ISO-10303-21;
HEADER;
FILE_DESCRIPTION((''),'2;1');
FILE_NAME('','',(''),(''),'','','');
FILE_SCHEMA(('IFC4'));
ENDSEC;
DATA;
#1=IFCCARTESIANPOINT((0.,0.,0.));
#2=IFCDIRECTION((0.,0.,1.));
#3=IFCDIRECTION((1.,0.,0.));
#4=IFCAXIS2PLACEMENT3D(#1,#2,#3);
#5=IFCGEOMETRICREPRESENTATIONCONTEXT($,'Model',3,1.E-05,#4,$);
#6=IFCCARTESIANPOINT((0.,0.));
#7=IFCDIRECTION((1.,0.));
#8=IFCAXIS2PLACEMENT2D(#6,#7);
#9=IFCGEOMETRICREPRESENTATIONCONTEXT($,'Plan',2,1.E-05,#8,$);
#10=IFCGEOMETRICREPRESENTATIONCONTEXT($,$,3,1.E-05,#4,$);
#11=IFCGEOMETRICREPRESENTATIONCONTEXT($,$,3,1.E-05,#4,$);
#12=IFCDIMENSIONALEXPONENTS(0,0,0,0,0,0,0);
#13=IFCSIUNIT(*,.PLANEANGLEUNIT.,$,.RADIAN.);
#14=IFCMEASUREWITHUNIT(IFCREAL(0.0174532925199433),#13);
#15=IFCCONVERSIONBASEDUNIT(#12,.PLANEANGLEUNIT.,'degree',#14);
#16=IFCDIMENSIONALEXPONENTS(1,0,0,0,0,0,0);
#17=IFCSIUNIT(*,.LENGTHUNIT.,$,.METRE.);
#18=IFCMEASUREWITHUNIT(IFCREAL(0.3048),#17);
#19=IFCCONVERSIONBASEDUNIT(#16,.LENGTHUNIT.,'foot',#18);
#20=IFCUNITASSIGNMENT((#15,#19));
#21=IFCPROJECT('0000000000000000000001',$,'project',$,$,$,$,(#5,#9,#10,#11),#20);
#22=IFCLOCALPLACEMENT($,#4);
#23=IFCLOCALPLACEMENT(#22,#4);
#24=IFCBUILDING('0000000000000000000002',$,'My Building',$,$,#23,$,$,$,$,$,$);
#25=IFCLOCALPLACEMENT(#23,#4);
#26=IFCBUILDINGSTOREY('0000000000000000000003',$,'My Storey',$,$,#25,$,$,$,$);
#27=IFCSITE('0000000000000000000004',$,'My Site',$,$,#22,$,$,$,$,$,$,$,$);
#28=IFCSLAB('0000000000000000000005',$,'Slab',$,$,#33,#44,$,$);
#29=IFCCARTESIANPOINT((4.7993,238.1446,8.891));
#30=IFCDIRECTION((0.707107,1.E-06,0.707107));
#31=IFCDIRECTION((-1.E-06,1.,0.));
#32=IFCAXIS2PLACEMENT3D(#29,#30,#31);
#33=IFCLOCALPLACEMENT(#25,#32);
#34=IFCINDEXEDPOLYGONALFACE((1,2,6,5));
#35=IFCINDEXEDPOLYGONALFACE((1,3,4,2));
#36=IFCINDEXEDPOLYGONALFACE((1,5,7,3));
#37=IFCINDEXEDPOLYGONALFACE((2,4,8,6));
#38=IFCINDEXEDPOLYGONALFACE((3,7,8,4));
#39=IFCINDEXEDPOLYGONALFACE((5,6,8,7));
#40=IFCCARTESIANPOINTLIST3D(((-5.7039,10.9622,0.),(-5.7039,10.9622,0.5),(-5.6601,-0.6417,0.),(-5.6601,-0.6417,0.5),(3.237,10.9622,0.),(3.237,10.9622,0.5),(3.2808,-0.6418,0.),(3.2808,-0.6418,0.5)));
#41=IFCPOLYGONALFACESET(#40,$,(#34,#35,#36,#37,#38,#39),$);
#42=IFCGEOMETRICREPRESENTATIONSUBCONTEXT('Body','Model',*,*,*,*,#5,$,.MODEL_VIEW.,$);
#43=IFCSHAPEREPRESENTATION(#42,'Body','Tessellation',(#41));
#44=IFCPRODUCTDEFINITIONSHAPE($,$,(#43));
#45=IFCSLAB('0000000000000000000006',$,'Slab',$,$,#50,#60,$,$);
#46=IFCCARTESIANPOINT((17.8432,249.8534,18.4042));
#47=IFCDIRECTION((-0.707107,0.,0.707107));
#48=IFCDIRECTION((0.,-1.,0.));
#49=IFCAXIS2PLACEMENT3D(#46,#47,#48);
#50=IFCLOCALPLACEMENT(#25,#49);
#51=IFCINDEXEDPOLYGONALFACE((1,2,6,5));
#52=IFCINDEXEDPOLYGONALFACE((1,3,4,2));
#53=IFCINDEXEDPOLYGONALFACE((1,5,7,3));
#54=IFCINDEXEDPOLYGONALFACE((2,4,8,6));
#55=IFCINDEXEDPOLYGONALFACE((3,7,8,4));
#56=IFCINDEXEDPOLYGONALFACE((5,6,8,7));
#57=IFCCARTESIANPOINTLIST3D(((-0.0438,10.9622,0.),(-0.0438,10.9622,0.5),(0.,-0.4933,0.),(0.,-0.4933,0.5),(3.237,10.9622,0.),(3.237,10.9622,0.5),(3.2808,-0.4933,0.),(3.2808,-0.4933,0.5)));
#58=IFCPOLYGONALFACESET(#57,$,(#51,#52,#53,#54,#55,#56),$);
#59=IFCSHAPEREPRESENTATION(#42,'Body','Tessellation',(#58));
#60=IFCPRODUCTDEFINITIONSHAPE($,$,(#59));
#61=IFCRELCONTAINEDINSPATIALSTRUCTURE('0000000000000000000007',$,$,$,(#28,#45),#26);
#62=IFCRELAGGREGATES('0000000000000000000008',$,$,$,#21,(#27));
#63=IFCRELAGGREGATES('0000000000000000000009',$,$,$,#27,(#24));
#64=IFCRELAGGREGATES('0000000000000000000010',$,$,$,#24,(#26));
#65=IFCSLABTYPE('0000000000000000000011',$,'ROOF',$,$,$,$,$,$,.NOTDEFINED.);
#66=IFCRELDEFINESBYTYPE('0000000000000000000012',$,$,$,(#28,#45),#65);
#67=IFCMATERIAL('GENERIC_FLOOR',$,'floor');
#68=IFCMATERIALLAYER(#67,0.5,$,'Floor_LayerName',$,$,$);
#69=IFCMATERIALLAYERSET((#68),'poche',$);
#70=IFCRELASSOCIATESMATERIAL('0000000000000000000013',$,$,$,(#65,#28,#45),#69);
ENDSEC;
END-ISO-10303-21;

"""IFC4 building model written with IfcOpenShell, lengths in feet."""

from ifc_helpers import new_model, entity, si_unit, converted_unit, frame, origin_with_axes, origin_2d_with_axis, place, context, subcontext, project, spatial, line, indexed_curve, outline, extrude, material, layer, layer_set, layer_usage, type_object, element, save


model = new_model("IFC4")

# Units and contexts
model_context = context("Model", 3, precision=1e-05, world=origin_with_axes())
plan_context = context("Plan", 2, precision=1e-05, world=origin_2d_with_axis())
context_of_model_1 = context(None, 3, precision=1e-05, world=origin_with_axes())
context_of_model_2 = context(None, 3, precision=1e-05, world=origin_with_axes())
body_context = subcontext(model_context, "Body", "Model", "MODEL_VIEW")
ifc_project = project(units=[converted_unit("PLANEANGLEUNIT", "degree", entity("IfcReal", 0.0174532925199433), si_unit("PLANEANGLEUNIT", "RADIAN"), dimensions=[0, 0, 0, 0, 0, 0, 0]), converted_unit("LENGTHUNIT", "foot", entity("IfcReal", 0.3048), si_unit("LENGTHUNIT", "METRE"), dimensions=[1, 0, 0, 0, 0, 0, 0])], contexts=[model_context, plan_context, context_of_model_1, context_of_model_2])

# Site, building, storey
site_placement = place(None, origin_with_axes())
site = spatial("IfcSite", under=ifc_project, at=site_placement, Name="My Site")
building_placement = place(site_placement, origin_with_axes())
building = spatial("IfcBuilding", under=site, at=building_placement, Name="My Building")
storey_placement = place(building_placement, origin_with_axes())
storey = spatial("IfcBuildingStorey", under=building, at=storey_placement, Name="My Storey")

# Slabs
ifc_material_1 = material(Name="GENERIC_FLOOR", Category="floor")
ifc_layer_1 = layer(ifc_material_1, 0.5, Name="Floor_LayerName")
ifc_layer_set_1 = layer_set([ifc_layer_1], Name="poche")
slab_type_1 = type_object("IfcSlabType", Name="ROOF", PredefinedType="NOTDEFINED", material=ifc_layer_set_1)
ifc_layer_usage_1 = layer_usage(ifc_layer_set_1, "AXIS3", "POSITIVE", 0.0)
slab_1_placement = place(storey_placement, frame((4.7993, 238.1446, 8.891), z_axis=(0.707107, 0.000001, 0.707107), x_axis=(-0.000001, 1.0, 0.0)))
element("IfcSlab", 1, at=slab_1_placement, inside=storey, type_object=slab_type_1, material=ifc_layer_usage_1, Name="Slab", context=body_context, shape_type="SweptSolid", body=[
    extrude(outline(indexed_curve([(3.237, 10.9622), (3.2808, -0.6418), (-5.6601, -0.6417), (-5.7039, 10.9622)], segments=[line(3, 2), line(2, 1), line(1, 4), line(4, 3)], self_intersect=False)), None, (0.0, 0.0, 1.0), 0.5),
])
ifc_layer_usage_2 = layer_usage(ifc_layer_set_1, "AXIS3", "POSITIVE", 0.0)
slab_2_placement = place(storey_placement, frame((17.8432, 249.8534, 18.4042), z_axis=(-0.707107, 0.0, 0.707107), x_axis=(0.0, -1.0, 0.0)))
element("IfcSlab", 2, at=slab_2_placement, inside=storey, type_object=slab_type_1, material=ifc_layer_usage_2, Name="Slab", context=body_context, shape_type="SweptSolid", body=[
    extrude(outline(indexed_curve([(3.237, 10.9622), (-0.0438, 10.9622), (0.0, -0.4933), (3.2808, -0.4933)], segments=[line(4, 1), line(1, 2), line(2, 3), line(3, 4)], self_intersect=False)), None, (0.0, 0.0, 1.0), 0.5),
])

save(model, "model.ifc")
